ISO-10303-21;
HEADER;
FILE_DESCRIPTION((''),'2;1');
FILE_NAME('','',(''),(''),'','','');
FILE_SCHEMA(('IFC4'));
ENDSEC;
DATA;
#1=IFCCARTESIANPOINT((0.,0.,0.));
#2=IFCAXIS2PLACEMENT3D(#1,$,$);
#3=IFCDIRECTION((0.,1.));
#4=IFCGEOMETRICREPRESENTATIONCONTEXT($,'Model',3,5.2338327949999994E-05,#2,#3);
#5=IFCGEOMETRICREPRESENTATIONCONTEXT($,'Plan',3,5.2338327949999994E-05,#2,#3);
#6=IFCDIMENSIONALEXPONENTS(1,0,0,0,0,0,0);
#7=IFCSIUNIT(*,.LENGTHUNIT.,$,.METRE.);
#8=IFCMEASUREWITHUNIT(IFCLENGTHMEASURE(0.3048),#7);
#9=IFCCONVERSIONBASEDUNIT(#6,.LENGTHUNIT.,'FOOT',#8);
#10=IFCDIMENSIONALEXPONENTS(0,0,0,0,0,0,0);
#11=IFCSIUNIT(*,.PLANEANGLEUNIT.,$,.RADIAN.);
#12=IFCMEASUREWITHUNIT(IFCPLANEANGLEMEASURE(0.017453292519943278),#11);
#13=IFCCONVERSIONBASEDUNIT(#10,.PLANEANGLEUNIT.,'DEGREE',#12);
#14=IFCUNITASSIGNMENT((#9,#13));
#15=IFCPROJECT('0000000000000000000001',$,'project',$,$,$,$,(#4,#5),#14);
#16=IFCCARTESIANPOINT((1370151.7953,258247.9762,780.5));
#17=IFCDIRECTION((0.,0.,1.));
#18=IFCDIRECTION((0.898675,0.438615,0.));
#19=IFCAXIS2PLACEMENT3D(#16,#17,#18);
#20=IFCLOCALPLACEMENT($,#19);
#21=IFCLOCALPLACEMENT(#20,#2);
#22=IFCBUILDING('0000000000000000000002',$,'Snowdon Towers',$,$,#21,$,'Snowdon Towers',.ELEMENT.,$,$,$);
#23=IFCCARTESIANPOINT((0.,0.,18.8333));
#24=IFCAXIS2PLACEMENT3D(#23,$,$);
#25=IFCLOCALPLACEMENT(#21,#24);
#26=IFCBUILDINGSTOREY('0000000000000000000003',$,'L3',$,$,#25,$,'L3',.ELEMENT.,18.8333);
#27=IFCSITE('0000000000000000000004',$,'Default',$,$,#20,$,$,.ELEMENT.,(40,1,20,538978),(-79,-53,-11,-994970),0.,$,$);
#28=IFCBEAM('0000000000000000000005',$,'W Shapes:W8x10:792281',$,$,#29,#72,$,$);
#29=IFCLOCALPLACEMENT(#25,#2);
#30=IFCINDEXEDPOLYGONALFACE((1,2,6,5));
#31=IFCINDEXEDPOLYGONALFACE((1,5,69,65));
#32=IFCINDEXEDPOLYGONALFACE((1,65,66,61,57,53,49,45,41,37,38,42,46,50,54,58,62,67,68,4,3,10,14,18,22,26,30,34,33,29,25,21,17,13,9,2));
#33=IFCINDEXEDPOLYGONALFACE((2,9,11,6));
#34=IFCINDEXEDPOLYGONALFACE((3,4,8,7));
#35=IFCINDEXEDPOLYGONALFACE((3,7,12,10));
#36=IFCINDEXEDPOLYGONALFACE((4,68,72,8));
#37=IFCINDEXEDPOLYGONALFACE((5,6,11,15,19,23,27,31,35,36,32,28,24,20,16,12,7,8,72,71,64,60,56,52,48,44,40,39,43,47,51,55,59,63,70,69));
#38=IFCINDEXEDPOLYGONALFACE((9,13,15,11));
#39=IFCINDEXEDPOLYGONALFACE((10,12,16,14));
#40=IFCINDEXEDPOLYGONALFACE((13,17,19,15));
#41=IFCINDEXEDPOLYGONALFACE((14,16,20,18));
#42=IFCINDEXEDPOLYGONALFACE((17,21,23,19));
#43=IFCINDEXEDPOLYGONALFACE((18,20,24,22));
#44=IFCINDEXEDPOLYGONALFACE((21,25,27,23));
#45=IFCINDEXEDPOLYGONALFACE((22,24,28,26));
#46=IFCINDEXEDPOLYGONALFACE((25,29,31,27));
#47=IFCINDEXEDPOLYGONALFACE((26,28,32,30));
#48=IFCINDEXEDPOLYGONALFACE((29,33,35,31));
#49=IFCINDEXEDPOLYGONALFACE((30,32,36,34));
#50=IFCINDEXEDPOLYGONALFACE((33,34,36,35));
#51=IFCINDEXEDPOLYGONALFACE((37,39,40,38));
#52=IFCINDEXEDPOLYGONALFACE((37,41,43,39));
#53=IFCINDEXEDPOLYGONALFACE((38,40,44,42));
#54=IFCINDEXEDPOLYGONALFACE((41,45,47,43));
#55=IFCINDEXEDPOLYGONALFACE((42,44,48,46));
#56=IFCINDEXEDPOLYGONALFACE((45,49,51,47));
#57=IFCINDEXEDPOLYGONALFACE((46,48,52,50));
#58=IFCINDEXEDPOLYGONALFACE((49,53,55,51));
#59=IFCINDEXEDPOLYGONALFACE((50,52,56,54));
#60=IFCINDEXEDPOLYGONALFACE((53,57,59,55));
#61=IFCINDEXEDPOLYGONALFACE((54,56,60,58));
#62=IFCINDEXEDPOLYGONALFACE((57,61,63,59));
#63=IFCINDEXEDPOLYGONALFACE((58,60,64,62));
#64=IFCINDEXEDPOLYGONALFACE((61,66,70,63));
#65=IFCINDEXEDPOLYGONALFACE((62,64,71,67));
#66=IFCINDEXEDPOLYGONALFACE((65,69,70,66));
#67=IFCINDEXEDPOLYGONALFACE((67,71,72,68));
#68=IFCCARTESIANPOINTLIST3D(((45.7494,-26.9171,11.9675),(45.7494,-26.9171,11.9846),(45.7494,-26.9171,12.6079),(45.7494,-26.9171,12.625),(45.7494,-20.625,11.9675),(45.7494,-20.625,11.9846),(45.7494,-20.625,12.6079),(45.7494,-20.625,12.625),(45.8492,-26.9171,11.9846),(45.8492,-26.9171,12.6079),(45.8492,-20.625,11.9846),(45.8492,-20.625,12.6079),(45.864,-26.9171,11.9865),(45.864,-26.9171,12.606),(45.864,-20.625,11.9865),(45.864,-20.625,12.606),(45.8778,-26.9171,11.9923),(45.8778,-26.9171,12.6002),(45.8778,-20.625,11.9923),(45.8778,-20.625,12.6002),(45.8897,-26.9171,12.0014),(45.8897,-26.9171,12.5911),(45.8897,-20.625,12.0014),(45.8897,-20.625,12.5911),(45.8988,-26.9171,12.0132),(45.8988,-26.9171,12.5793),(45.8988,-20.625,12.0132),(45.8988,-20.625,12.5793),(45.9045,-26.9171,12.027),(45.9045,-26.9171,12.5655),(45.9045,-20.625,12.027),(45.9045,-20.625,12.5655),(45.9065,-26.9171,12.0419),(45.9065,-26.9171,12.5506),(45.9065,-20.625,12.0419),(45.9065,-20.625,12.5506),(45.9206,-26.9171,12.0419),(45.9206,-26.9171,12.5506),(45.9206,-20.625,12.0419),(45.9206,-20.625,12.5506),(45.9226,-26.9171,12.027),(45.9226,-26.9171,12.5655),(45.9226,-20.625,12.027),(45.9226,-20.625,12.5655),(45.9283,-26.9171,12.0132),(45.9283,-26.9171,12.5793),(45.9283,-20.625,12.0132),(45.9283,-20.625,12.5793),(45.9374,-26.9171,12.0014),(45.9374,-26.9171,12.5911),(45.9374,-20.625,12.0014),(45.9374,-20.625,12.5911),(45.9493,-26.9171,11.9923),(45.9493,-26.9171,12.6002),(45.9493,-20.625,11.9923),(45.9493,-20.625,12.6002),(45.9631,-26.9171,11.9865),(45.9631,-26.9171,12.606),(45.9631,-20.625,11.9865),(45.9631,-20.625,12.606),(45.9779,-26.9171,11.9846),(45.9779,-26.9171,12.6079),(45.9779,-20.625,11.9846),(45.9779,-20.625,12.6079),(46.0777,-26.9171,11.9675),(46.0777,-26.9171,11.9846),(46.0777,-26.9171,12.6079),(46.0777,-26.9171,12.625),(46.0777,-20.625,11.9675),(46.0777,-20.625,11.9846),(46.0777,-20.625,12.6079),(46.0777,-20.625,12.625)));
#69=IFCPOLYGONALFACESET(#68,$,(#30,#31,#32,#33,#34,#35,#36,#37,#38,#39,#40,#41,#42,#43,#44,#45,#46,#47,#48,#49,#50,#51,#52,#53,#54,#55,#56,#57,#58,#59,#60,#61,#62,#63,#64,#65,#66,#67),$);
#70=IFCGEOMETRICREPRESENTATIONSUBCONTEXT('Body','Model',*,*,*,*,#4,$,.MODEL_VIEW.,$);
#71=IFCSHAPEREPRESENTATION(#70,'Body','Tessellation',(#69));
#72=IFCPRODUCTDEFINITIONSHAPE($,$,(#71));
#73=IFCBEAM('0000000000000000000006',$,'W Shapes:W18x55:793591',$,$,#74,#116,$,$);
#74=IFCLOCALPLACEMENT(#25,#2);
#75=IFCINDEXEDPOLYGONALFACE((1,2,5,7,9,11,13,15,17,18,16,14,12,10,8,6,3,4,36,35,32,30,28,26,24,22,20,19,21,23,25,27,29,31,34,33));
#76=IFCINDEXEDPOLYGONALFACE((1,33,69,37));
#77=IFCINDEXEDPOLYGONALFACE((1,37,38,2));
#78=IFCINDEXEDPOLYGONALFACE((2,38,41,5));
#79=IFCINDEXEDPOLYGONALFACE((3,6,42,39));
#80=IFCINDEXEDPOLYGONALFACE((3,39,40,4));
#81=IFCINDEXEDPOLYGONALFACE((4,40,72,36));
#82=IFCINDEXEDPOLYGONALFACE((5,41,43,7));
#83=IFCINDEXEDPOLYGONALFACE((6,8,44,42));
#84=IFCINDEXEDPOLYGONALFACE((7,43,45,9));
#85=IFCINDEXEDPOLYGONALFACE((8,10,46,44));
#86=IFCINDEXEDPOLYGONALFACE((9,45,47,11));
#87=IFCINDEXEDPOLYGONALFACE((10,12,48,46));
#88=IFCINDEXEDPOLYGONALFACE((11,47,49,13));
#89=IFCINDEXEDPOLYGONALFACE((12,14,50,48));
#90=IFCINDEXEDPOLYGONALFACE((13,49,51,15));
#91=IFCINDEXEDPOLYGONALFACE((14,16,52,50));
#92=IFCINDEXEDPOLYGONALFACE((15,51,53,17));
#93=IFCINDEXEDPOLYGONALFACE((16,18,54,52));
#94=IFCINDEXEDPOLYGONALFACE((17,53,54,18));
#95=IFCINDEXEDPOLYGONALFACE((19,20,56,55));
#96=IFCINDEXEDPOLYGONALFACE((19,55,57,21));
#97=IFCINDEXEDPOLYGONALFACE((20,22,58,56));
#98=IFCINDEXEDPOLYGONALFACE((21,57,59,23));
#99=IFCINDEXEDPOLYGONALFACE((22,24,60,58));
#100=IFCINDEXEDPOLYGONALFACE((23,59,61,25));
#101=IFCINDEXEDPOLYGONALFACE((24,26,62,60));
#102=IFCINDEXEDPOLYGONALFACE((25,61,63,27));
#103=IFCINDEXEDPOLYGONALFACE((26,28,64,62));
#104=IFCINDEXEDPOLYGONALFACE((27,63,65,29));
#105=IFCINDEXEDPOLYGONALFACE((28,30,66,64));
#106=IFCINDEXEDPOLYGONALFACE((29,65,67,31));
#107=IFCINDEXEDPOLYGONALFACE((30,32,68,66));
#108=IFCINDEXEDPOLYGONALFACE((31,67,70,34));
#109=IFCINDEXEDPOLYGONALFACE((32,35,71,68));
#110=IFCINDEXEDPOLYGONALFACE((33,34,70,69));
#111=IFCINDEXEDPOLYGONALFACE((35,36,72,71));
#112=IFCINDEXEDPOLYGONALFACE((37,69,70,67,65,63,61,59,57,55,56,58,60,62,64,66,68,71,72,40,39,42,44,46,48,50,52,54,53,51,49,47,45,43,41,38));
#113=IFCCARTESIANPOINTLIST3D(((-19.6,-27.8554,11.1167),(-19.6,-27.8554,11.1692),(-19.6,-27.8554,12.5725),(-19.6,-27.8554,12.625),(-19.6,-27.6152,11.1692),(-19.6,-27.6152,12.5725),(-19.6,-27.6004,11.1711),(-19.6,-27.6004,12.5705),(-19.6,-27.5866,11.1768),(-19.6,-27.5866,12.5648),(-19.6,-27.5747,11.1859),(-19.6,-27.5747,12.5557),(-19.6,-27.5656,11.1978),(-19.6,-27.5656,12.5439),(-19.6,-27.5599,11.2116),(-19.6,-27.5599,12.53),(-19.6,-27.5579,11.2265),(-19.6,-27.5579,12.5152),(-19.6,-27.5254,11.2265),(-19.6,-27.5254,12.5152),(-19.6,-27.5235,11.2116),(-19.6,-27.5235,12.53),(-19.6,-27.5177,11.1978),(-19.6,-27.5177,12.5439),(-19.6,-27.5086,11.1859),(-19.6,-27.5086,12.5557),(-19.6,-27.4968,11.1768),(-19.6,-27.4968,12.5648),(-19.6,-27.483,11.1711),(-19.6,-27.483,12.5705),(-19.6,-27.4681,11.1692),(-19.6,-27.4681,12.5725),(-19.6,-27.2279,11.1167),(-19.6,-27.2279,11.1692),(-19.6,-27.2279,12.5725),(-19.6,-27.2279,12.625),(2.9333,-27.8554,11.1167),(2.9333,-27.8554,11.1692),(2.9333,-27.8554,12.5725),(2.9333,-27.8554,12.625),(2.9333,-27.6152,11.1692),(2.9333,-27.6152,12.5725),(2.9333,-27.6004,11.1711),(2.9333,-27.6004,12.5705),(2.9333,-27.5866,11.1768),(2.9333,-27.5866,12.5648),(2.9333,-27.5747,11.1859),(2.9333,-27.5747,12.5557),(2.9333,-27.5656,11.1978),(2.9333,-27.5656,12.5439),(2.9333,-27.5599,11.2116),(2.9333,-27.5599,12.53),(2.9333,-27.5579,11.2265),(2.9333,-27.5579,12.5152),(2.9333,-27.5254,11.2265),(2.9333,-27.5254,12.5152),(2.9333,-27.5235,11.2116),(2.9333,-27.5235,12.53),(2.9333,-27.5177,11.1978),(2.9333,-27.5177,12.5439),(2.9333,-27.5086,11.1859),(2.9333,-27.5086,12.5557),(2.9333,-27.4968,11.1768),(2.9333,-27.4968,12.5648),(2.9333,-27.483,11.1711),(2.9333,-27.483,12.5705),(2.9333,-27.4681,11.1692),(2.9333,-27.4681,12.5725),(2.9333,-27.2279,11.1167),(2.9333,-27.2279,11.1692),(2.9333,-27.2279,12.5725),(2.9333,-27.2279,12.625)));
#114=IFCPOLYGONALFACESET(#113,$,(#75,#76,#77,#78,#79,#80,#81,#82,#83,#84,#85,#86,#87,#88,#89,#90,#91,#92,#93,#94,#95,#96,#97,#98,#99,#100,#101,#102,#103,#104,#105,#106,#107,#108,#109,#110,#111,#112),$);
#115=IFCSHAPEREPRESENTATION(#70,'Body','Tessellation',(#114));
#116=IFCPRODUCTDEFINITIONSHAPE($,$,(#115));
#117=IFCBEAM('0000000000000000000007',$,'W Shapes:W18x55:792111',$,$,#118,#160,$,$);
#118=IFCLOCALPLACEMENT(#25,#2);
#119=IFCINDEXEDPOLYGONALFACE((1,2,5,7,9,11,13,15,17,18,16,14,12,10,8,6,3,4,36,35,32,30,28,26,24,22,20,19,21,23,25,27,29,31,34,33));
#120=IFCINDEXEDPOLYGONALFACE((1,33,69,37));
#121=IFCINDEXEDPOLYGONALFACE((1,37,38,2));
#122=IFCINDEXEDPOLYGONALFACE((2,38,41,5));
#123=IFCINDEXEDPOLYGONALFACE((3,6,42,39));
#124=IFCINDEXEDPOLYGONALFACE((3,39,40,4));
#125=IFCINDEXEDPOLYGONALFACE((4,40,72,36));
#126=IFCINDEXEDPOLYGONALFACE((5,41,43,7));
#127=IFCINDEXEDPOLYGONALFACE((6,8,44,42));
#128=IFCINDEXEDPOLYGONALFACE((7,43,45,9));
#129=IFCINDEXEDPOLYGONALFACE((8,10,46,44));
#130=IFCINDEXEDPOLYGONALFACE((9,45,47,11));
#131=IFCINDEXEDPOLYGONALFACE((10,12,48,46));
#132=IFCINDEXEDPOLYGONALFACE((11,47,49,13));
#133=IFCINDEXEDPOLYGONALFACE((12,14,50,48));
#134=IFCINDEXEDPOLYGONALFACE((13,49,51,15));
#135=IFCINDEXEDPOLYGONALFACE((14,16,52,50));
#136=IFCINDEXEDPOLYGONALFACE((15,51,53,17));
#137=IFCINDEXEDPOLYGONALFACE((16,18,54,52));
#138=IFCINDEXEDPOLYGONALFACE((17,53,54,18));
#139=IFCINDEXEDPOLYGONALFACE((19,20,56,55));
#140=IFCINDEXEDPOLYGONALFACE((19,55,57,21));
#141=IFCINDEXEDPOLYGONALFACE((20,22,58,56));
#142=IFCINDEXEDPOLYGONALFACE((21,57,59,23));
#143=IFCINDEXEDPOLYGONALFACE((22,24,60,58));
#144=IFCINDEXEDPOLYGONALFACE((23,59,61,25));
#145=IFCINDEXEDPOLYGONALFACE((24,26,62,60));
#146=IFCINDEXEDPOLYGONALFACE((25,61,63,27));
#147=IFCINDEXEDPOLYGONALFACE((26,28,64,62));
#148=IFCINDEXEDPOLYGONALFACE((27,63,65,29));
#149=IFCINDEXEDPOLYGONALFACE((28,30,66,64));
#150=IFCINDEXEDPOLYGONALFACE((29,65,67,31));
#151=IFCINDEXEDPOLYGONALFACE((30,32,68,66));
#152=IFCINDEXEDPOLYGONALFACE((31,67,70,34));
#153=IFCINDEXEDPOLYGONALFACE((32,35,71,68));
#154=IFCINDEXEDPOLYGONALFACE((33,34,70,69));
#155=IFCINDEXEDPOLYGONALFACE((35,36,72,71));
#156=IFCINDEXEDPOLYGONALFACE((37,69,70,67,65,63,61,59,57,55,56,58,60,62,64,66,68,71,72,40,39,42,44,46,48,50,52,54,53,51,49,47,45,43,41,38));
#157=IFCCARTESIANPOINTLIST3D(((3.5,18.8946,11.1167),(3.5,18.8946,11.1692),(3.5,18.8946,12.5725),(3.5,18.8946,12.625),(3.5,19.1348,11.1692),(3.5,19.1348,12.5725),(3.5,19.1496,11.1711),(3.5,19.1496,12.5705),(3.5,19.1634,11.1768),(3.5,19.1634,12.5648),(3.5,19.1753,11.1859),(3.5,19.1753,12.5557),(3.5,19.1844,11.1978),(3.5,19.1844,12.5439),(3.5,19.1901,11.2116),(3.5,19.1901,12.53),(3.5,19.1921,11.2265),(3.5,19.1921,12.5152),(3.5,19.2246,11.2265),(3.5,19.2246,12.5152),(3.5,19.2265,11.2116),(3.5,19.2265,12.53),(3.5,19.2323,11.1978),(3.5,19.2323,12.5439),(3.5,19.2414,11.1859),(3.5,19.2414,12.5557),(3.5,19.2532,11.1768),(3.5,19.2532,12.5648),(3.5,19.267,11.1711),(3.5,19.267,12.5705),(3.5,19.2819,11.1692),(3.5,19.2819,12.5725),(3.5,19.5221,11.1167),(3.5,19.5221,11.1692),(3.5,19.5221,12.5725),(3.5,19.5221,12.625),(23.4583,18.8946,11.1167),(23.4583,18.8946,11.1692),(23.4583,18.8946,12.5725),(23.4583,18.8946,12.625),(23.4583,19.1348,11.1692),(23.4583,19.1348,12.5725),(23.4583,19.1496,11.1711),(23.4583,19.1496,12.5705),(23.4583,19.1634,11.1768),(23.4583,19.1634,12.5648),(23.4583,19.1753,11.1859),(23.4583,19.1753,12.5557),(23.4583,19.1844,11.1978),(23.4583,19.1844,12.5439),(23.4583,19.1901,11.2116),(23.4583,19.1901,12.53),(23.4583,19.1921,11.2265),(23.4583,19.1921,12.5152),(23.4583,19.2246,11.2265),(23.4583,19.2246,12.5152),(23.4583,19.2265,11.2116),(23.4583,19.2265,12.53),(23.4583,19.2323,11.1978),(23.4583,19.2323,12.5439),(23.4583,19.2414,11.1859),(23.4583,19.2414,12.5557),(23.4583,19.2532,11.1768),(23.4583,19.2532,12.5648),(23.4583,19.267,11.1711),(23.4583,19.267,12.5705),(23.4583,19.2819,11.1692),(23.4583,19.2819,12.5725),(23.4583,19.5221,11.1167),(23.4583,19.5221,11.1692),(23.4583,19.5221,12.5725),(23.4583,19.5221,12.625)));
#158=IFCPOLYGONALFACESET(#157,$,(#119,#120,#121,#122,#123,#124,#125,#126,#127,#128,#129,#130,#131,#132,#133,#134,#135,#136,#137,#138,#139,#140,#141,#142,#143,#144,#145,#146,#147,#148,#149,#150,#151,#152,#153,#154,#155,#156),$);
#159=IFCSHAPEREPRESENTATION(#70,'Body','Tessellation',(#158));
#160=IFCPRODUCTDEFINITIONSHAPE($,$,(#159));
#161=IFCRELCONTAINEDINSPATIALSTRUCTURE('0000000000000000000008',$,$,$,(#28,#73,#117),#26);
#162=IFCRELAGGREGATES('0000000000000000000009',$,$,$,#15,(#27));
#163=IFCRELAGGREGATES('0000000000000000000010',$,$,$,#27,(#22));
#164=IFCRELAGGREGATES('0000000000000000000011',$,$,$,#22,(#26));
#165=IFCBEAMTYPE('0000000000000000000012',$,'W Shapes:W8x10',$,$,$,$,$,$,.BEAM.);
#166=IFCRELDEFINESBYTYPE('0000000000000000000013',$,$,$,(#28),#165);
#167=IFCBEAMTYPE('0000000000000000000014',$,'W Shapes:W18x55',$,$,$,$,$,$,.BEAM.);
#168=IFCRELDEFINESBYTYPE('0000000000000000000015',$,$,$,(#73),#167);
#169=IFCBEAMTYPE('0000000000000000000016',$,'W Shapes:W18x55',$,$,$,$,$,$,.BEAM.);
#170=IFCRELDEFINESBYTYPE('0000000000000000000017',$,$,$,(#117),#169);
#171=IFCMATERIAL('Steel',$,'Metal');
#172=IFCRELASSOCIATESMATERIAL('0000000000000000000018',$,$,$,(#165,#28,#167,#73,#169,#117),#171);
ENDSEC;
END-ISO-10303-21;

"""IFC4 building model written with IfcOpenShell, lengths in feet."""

from ifc_helpers import new_model, entity, si_unit, converted_unit, direction, frame, origin, place, context, subcontext, project, spatial, line, arc, indexed_curve, outline, extrude, source, transform, mapped, material, type_object, type_shapes, element, save


model = new_model("IFC4")

# Units and contexts
model_context = context("Model", 3, precision=5.2338327949999994e-05, world=origin(), true_north=direction((0.0, 1.0)))
plan_context = context("Plan", 3, precision=5.2338327949999994e-05, world=origin(), true_north=direction((0.0, 1.0)))
body_context = subcontext(model_context, "Body", "Model", "MODEL_VIEW")
ifc_project = project(units=[converted_unit("LENGTHUNIT", "FOOT", entity("IfcLengthMeasure", 0.3048), si_unit("LENGTHUNIT", "METRE"), dimensions=[1, 0, 0, 0, 0, 0, 0]), converted_unit("PLANEANGLEUNIT", "DEGREE", entity("IfcPlaneAngleMeasure", 0.017453292519943278), si_unit("PLANEANGLEUNIT", "RADIAN"), dimensions=[0, 0, 0, 0, 0, 0, 0])], contexts=[model_context, plan_context])

# Site, building, storey
site_placement = place(None, frame((1370151.7953, 258247.9762, 780.5), z_axis=(0.0, 0.0, 1.0), x_axis=(0.898675, 0.438615, 0.0)))
site = spatial("IfcSite", under=ifc_project, at=site_placement, Name="Default", CompositionType="ELEMENT", RefLatitude=(40, 1, 20, 538978), RefLongitude=(-79, -53, -11, -994970), RefElevation=0.0)
building_placement = place(site_placement, origin())
building = spatial("IfcBuilding", under=site, at=building_placement, Name="Snowdon Towers", LongName="Snowdon Towers", CompositionType="ELEMENT")
storey_placement = place(building_placement, frame((0.0, 0.0, 18.8333)))
storey = spatial("IfcBuildingStorey", under=building, at=storey_placement, Name="L3", LongName="L3", CompositionType="ELEMENT", Elevation=18.8333)

# Beams
ifc_material_1 = material(Name="Steel", Category="Metal")
beam_type_1 = type_object("IfcBeamType", Name="W Shapes:W8x10", PredefinedType="BEAM", material=ifc_material_1)
shared_shape_1 = source(origin(), body_context, "Body", "SweptSolid", [
    extrude(outline(indexed_curve([(-0.3287, -0.1642), (-0.3117, -0.1642), (-0.3117, -0.0644), (-0.2949, -0.0239), (-0.2544, -0.0071), (0.2544, -0.0071), (0.2949, -0.0239), (0.3117, -0.0644), (0.3117, -0.1642), (0.3288, -0.1642), (0.3288, 0.1642), (0.3117, 0.1642), (0.3117, 0.0644), (0.2949, 0.0239), (0.2544, 0.0071), (-0.2544, 0.0071), (-0.2949, 0.0239), (-0.3117, 0.0644), (-0.3117, 0.1642), (-0.3287, 0.1642)], segments=[line(1, 2, 3), arc(3, 4, 5), line(5, 6), arc(6, 7, 8), line(8, 9, 10, 11, 12, 13), arc(13, 14, 15), line(15, 16), arc(16, 17, 18), line(18, 19, 20, 1)], self_intersect=False)), frame((-3.0585, 0.0, 0.0), z_axis=(1.0, 0.0, 0.0), x_axis=(0.0, 0.0, -1.0)), (0.0, 0.0, 1.0), 6.2921),
])
type_shapes(beam_type_1, [shared_shape_1])
beam_1_placement = place(storey_placement, frame((45.9135, -23.6835, 12.2963), z_axis=(0.0, 0.0, 1.0), x_axis=(0.0, -1.0, 0.0)))
element("IfcBeam", 1, at=beam_1_placement, inside=storey, type_object=beam_type_1, material=ifc_material_1, Name="W Shapes:W8x10:792281", context=body_context, shape_type="MappedRepresentation", body=[
    mapped(shared_shape_1, transform((0.0, 0.0, 0.0), scale=1.0)),
])
beam_type_2 = type_object("IfcBeamType", Name="W Shapes:W18x55", PredefinedType="BEAM", material=ifc_material_1)
shared_shape_2 = source(origin(), body_context, "Body", "SweptSolid", [
    extrude(outline(indexed_curve([(-0.7542, -0.3138), (-0.7017, -0.3138), (-0.7017, -0.0735), (-0.6849, -0.033), (-0.6444, -0.0162), (0.6444, -0.0162), (0.6849, -0.033), (0.7017, -0.0735), (0.7017, -0.3138), (0.7542, -0.3138), (0.7542, 0.3138), (0.7017, 0.3138), (0.7017, 0.0735), (0.6849, 0.033), (0.6444, 0.0163), (-0.6444, 0.0163), (-0.6849, 0.033), (-0.7017, 0.0735), (-0.7017, 0.3137), (-0.7542, 0.3137)], segments=[line(1, 2, 3), arc(3, 4, 5), line(5, 6), arc(6, 7, 8), line(8, 9, 10, 11, 12, 13), arc(13, 14, 15), line(15, 16), arc(16, 17, 18), line(18, 19, 20, 1)], self_intersect=False)), frame((-11.2667, 0.0, 0.0), z_axis=(1.0, 0.0, 0.0), x_axis=(0.0, 0.0, -1.0)), (0.0, 0.0, 1.0), 22.5333),
])
type_shapes(beam_type_2, [shared_shape_2])
beam_2_placement = place(storey_placement, frame((-8.3333, -27.5417, 11.8708)))
element("IfcBeam", 2, at=beam_2_placement, inside=storey, type_object=beam_type_2, material=ifc_material_1, Name="W Shapes:W18x55:793591", context=body_context, shape_type="MappedRepresentation", body=[
    mapped(shared_shape_2, transform((0.0, 0.0, 0.0), scale=1.0)),
])
beam_type_3 = type_object("IfcBeamType", Name="W Shapes:W18x55", PredefinedType="BEAM", material=ifc_material_1)
shared_shape_3 = source(origin(), body_context, "Body", "SweptSolid", [
    extrude(outline(indexed_curve([(-0.7542, -0.3138), (-0.7017, -0.3138), (-0.7017, -0.0735), (-0.6849, -0.033), (-0.6444, -0.0162), (0.6444, -0.0162), (0.6849, -0.033), (0.7017, -0.0735), (0.7017, -0.3138), (0.7542, -0.3138), (0.7542, 0.3138), (0.7017, 0.3138), (0.7017, 0.0735), (0.6849, 0.033), (0.6444, 0.0163), (-0.6444, 0.0163), (-0.6849, 0.033), (-0.7017, 0.0735), (-0.7017, 0.3137), (-0.7542, 0.3137)], segments=[line(1, 2, 3), arc(3, 4, 5), line(5, 6), arc(6, 7, 8), line(8, 9, 10, 11, 12, 13), arc(13, 14, 15), line(15, 16), arc(16, 17, 18), line(18, 19, 20, 1)], self_intersect=False)), frame((-10.2083, 0.0, 0.0), z_axis=(1.0, 0.0, 0.0), x_axis=(0.0, 0.0, -1.0)), (0.0, 0.0, 1.0), 19.9583),
])
type_shapes(beam_type_3, [shared_shape_3])
beam_3_placement = place(storey_placement, frame((13.7083, 19.2083, 11.8708)))
element("IfcBeam", 3, at=beam_3_placement, inside=storey, type_object=beam_type_3, material=ifc_material_1, Name="W Shapes:W18x55:792111", context=body_context, shape_type="MappedRepresentation", body=[
    mapped(shared_shape_3, transform((0.0, 0.0, 0.0), scale=1.0)),
])

save(model, "model.ifc")
